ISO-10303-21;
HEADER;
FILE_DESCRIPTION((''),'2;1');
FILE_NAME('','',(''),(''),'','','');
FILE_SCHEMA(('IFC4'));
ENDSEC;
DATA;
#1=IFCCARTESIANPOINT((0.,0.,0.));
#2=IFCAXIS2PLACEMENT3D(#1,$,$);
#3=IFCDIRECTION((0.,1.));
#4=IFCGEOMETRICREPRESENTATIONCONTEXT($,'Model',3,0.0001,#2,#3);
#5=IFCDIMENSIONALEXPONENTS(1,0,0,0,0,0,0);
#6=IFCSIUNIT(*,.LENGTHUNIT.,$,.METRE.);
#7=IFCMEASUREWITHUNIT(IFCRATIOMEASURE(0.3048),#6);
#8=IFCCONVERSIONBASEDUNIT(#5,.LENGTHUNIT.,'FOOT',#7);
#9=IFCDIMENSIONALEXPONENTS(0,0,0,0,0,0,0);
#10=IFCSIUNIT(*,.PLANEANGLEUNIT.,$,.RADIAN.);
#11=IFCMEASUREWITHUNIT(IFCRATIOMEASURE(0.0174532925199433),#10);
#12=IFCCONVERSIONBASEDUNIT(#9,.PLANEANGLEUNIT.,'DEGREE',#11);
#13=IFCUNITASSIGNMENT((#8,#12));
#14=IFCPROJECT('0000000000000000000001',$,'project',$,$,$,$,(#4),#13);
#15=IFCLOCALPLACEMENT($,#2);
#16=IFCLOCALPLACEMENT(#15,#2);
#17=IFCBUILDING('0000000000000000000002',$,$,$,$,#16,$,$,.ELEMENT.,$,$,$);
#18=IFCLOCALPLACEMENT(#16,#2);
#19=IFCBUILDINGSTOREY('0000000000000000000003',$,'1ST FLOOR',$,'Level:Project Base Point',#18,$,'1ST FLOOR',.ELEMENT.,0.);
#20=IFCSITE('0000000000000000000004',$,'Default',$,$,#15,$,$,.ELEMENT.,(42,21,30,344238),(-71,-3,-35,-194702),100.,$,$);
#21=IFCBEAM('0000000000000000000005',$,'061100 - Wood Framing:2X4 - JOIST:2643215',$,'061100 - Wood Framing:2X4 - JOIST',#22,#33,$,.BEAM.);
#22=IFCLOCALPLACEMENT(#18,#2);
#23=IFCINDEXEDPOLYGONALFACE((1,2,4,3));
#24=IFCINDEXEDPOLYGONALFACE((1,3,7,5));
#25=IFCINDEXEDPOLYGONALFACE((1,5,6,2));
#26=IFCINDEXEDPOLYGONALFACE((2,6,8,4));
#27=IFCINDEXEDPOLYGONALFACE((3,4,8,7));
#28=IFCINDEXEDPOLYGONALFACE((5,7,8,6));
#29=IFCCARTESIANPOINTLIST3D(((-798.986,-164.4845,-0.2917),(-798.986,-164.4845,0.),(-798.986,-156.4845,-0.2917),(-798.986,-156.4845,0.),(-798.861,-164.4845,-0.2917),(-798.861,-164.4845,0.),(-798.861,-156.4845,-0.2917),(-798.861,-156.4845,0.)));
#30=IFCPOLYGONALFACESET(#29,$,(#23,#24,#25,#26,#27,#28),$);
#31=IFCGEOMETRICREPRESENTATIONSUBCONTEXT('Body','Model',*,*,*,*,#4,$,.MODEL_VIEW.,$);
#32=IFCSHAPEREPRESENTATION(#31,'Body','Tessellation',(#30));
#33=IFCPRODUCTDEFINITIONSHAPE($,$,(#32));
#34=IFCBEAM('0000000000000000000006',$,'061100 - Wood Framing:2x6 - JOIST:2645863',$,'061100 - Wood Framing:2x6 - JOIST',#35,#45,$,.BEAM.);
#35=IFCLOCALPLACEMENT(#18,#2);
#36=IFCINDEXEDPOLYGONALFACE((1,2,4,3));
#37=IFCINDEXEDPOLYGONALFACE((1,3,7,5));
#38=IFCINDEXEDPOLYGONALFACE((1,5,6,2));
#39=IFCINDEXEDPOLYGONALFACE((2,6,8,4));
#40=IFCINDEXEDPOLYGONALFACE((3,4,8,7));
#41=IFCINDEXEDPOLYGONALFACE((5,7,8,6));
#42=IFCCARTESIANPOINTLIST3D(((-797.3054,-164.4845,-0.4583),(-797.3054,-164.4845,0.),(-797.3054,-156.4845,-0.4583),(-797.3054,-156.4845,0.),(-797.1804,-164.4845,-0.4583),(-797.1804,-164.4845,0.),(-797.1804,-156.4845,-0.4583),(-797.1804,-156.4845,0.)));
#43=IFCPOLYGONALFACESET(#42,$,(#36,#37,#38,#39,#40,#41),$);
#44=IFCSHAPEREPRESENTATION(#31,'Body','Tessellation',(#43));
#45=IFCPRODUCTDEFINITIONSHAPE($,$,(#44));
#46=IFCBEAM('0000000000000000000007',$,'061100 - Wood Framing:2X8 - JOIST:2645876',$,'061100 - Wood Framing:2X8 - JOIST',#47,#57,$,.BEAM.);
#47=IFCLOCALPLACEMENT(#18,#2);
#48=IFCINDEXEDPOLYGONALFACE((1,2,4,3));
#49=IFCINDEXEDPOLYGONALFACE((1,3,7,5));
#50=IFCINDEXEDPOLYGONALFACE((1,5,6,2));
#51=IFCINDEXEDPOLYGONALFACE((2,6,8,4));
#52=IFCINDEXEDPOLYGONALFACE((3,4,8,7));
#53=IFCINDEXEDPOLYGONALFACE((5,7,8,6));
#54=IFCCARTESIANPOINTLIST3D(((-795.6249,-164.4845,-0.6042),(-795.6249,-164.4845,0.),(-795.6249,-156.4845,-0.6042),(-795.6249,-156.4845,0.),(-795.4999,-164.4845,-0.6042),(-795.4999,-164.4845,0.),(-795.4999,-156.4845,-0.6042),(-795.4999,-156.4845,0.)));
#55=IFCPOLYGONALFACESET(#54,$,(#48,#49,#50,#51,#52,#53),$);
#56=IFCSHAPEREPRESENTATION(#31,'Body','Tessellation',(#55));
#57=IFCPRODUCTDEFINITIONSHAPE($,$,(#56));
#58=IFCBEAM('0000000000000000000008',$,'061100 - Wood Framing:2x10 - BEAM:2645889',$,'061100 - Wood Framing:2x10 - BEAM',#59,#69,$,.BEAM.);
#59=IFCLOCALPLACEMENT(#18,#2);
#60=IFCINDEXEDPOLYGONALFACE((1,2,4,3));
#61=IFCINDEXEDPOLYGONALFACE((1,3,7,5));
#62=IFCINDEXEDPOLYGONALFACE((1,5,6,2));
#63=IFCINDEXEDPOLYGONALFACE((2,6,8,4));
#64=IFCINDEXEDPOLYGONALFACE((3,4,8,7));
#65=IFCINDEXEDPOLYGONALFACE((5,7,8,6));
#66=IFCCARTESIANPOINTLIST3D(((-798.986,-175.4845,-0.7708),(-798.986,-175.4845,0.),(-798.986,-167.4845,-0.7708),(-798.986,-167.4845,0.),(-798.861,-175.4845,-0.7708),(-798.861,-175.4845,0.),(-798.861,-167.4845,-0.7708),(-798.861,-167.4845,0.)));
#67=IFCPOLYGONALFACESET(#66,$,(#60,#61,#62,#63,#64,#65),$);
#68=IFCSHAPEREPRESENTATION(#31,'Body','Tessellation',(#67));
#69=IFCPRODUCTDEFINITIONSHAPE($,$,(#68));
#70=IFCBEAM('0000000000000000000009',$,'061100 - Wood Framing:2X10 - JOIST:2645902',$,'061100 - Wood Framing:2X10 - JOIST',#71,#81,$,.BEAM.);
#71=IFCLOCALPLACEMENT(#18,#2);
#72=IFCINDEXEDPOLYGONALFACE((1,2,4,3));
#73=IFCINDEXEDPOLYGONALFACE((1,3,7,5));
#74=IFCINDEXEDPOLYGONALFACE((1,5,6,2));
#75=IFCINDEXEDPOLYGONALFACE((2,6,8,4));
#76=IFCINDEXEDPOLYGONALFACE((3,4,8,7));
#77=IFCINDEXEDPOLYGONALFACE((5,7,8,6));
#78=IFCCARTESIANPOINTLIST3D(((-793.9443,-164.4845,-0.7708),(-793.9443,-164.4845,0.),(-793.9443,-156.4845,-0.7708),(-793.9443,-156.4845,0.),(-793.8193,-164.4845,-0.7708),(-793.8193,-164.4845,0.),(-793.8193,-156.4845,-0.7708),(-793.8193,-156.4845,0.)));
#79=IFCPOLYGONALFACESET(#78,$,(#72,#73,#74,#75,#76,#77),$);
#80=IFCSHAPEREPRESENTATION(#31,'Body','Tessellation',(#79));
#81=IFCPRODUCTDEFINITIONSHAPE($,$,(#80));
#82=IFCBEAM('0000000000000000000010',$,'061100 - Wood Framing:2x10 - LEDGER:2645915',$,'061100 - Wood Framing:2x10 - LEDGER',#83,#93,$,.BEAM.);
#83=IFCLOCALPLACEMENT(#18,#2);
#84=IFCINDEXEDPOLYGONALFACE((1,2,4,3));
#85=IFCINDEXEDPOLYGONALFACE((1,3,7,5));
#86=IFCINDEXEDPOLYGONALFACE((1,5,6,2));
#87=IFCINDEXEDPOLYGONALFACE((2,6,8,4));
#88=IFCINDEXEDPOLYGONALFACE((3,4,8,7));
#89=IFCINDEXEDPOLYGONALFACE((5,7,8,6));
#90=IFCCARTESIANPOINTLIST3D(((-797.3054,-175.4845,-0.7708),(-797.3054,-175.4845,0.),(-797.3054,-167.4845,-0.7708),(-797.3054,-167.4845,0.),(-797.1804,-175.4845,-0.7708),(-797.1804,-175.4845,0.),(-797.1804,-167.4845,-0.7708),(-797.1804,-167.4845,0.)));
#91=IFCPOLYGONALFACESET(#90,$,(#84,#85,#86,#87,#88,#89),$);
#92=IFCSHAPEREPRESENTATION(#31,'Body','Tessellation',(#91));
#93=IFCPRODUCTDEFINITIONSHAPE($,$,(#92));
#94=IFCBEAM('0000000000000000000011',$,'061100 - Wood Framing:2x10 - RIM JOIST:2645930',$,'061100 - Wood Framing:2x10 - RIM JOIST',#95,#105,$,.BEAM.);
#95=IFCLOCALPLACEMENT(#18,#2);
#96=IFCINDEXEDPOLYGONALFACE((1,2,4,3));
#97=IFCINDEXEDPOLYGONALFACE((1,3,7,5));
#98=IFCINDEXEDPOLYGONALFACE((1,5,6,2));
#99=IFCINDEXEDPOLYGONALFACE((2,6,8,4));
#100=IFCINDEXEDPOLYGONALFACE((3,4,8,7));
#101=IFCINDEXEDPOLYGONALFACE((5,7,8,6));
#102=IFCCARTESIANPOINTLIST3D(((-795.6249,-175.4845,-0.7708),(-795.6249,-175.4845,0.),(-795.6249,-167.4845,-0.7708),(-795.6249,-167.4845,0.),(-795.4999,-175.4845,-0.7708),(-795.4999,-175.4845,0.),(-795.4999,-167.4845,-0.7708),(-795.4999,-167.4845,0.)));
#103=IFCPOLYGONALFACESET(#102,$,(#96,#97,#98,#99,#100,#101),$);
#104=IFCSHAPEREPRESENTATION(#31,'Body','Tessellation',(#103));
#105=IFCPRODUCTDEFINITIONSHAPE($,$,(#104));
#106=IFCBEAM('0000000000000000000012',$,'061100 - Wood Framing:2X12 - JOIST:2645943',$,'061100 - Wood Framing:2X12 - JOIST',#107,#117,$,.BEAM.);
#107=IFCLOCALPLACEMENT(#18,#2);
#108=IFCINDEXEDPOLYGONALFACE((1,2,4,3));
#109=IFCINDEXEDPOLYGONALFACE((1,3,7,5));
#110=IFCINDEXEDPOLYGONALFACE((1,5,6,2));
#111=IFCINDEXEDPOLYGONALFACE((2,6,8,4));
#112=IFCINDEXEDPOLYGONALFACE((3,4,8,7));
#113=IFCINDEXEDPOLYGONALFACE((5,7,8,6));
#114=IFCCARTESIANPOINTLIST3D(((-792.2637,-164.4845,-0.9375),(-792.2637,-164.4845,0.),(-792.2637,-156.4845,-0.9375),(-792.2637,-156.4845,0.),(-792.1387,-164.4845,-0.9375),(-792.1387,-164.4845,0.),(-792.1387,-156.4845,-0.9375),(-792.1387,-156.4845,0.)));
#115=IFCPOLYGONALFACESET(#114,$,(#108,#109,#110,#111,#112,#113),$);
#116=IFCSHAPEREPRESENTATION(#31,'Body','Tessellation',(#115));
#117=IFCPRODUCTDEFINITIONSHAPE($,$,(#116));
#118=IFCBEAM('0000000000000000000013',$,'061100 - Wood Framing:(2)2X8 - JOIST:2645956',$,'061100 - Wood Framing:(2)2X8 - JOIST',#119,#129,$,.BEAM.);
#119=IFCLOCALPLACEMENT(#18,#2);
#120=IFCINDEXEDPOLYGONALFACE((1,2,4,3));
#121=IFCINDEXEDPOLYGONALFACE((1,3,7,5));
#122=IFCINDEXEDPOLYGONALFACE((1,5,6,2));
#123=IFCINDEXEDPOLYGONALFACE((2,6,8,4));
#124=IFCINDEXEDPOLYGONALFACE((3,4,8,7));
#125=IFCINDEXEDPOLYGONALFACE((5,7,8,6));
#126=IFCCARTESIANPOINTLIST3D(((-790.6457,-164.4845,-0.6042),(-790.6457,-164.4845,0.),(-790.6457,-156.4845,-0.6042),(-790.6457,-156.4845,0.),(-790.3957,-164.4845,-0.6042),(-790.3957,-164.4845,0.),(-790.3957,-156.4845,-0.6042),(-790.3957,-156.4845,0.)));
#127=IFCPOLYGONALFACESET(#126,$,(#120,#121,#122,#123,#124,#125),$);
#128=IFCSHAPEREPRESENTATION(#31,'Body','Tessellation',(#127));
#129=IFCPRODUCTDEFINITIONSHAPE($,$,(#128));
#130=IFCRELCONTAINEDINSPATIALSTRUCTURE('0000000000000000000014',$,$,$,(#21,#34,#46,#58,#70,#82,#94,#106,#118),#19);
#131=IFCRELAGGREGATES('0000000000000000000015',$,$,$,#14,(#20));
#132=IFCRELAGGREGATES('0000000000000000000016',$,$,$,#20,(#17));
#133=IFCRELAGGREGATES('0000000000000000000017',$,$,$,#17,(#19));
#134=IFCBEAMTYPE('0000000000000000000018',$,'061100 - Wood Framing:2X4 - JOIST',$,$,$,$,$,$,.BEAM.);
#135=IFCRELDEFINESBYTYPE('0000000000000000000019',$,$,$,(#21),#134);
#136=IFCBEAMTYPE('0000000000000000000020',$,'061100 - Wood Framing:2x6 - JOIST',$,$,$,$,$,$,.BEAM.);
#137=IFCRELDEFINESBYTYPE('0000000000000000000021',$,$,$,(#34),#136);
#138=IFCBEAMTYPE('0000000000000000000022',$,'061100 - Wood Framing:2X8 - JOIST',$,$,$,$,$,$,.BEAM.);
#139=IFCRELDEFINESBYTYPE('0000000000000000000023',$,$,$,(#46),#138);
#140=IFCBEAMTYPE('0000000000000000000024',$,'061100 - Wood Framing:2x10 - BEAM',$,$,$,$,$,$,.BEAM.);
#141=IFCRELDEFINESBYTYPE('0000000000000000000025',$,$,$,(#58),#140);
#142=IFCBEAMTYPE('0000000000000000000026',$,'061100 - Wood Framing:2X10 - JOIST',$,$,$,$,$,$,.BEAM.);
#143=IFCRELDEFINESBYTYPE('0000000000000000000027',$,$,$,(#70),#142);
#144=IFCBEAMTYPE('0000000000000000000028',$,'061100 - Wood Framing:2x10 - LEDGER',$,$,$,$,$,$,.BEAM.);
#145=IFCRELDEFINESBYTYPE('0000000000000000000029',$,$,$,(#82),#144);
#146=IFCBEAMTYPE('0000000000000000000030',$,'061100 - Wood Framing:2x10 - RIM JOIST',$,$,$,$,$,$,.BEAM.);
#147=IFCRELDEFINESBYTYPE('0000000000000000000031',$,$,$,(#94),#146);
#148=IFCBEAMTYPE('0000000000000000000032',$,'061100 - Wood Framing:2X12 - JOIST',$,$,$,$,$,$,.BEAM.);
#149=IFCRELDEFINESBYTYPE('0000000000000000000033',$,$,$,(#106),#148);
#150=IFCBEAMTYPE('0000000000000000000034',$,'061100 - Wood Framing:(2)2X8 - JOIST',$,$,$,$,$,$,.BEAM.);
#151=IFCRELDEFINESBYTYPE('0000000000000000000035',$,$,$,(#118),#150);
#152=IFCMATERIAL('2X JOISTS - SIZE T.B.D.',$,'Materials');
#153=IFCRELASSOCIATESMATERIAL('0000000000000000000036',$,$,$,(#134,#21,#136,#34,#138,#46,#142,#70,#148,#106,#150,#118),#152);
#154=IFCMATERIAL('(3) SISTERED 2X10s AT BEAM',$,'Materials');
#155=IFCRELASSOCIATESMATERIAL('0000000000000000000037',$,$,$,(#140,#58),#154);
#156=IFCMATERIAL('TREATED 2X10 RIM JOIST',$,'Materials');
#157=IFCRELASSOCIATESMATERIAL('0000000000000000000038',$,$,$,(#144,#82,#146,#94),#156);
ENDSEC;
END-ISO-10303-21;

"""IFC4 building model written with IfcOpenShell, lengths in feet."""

from ifc_helpers import new_model, entity, si_unit, converted_unit, direction, frame, frame_2d, origin, origin_2d_with_axis, place, context, subcontext, project, spatial, rectangle, extrude, source, transform, mapped, material, material_profile, profile_set, profile_usage, type_object, type_shapes, element, save


model = new_model("IFC4")

# Units and contexts
model_context = context("Model", 3, precision=0.0001, world=origin(), true_north=direction((0.0, 1.0)))
body_context = subcontext(model_context, "Body", "Model", "MODEL_VIEW")
ifc_project = project(units=[converted_unit("LENGTHUNIT", "FOOT", entity("IfcRatioMeasure", 0.3048), si_unit("LENGTHUNIT", "METRE"), dimensions=[1, 0, 0, 0, 0, 0, 0]), converted_unit("PLANEANGLEUNIT", "DEGREE", entity("IfcRatioMeasure", 0.0174532925199433), si_unit("PLANEANGLEUNIT", "RADIAN"), dimensions=[0, 0, 0, 0, 0, 0, 0])], contexts=[model_context])

# Site, building, storey
site_placement = place(None, origin())
site = spatial("IfcSite", under=ifc_project, at=site_placement, Name="Default", CompositionType="ELEMENT", RefLatitude=(42, 21, 30, 344238), RefLongitude=(-71, -3, -35, -194702), RefElevation=100.0)
building_placement = place(site_placement, origin())
building = spatial("IfcBuilding", under=site, at=building_placement, CompositionType="ELEMENT")
storey_placement = place(building_placement, origin())
storey = spatial("IfcBuildingStorey", under=building, at=storey_placement, Name="1ST FLOOR", ObjectType="Level:Project Base Point", LongName="1ST FLOOR", CompositionType="ELEMENT", Elevation=0.0)

# Beams
ifc_material_1 = material(Name="2X JOISTS - SIZE T.B.D.", Category="Materials")
ifc_material_profile_1 = material_profile(ifc_material_1, rectangle(XDim=0.2917, YDim=0.125, at=origin_2d_with_axis()), Name="2X4 - JOIST")
ifc_profile_set_1 = profile_set([ifc_material_profile_1], Name="2X4 - JOIST")
ifc_profile_usage_1 = profile_usage(ifc_profile_set_1, cardinal=8)
beam_type_1 = type_object("IfcBeamType", Name="061100 - Wood Framing:2X4 - JOIST", PredefinedType="BEAM", material=ifc_profile_set_1)
shared_shape_1 = source(origin(), body_context, "Body", "SweptSolid", [
    extrude(rectangle(XDim=0.2917, YDim=0.125, at=origin_2d_with_axis()), frame((-4.0, 0.0, 0.0), z_axis=(1.0, 0.0, 0.0), x_axis=(0.0, 0.0, -1.0)), (0.0, 0.0, 1.0), 8.0),
])
type_shapes(beam_type_1, [shared_shape_1])
beam_1_placement = place(storey_placement, frame((-798.9235, -160.4845, -0.1458), z_axis=(0.0, 0.0, 1.0), x_axis=(0.0, -1.0, 0.0)))
element("IfcBeam", 1, at=beam_1_placement, inside=storey, type_object=beam_type_1, material=ifc_profile_usage_1, Name="061100 - Wood Framing:2X4 - JOIST:2643215", ObjectType="061100 - Wood Framing:2X4 - JOIST", PredefinedType="BEAM", context=body_context, shape_type="MappedRepresentation", body=[
    mapped(shared_shape_1, transform((0.0, 0.0, 0.0), scale=1.0)),
])
ifc_material_profile_2 = material_profile(ifc_material_1, rectangle(XDim=0.4583, YDim=0.125, at=origin_2d_with_axis()), Name="2x6 - JOIST")
ifc_profile_set_2 = profile_set([ifc_material_profile_2], Name="2x6 - JOIST")
ifc_profile_usage_2 = profile_usage(ifc_profile_set_2, cardinal=8)
beam_type_2 = type_object("IfcBeamType", Name="061100 - Wood Framing:2x6 - JOIST", PredefinedType="BEAM", material=ifc_profile_set_2)
shared_shape_2 = source(origin(), body_context, "Body", "SweptSolid", [
    extrude(rectangle(XDim=0.4583, YDim=0.125, at=origin_2d_with_axis()), frame((-4.0, 0.0, 0.0), z_axis=(1.0, 0.0, 0.0), x_axis=(0.0, 0.0, -1.0)), (0.0, 0.0, 1.0), 8.0),
])
type_shapes(beam_type_2, [shared_shape_2])
beam_2_placement = place(storey_placement, frame((-797.2429, -160.4845, -0.2292), z_axis=(0.0, 0.0, 1.0), x_axis=(0.0, -1.0, 0.0)))
element("IfcBeam", 2, at=beam_2_placement, inside=storey, type_object=beam_type_2, material=ifc_profile_usage_2, Name="061100 - Wood Framing:2x6 - JOIST:2645863", ObjectType="061100 - Wood Framing:2x6 - JOIST", PredefinedType="BEAM", context=body_context, shape_type="MappedRepresentation", body=[
    mapped(shared_shape_2, transform((0.0, 0.0, 0.0), scale=1.0)),
])
ifc_material_profile_3 = material_profile(ifc_material_1, rectangle(XDim=0.6042, YDim=0.125, at=origin_2d_with_axis()), Name="2X8 - JOIST")
ifc_profile_set_3 = profile_set([ifc_material_profile_3], Name="2X8 - JOIST")
ifc_profile_usage_3 = profile_usage(ifc_profile_set_3, cardinal=8)
beam_type_3 = type_object("IfcBeamType", Name="061100 - Wood Framing:2X8 - JOIST", PredefinedType="BEAM", material=ifc_profile_set_3)
shared_shape_3 = source(origin(), body_context, "Body", "SweptSolid", [
    extrude(rectangle(XDim=0.6042, YDim=0.125, at=origin_2d_with_axis()), frame((-4.0, 0.0, 0.0), z_axis=(1.0, 0.0, 0.0), x_axis=(0.0, 0.0, -1.0)), (0.0, 0.0, 1.0), 8.0),
])
type_shapes(beam_type_3, [shared_shape_3])
beam_3_placement = place(storey_placement, frame((-795.5624, -160.4845, -0.3021), z_axis=(0.0, 0.0, 1.0), x_axis=(0.0, -1.0, 0.0)))
element("IfcBeam", 3, at=beam_3_placement, inside=storey, type_object=beam_type_3, material=ifc_profile_usage_3, Name="061100 - Wood Framing:2X8 - JOIST:2645876", ObjectType="061100 - Wood Framing:2X8 - JOIST", PredefinedType="BEAM", context=body_context, shape_type="MappedRepresentation", body=[
    mapped(shared_shape_3, transform((0.0, 0.0, 0.0), scale=1.0)),
])
ifc_material_2 = material(Name="(3) SISTERED 2X10s AT BEAM", Category="Materials")
ifc_material_profile_4 = material_profile(ifc_material_2, rectangle(XDim=0.7708, YDim=0.125, at=frame_2d((0.0, 0.0), x_axis=(1.0, 0.0))), Name="2x10 - BEAM")
ifc_profile_set_4 = profile_set([ifc_material_profile_4], Name="2x10 - BEAM")
ifc_profile_usage_4 = profile_usage(ifc_profile_set_4, cardinal=8)
beam_type_4 = type_object("IfcBeamType", Name="061100 - Wood Framing:2x10 - BEAM", PredefinedType="BEAM", material=ifc_profile_set_4)
shared_shape_4 = source(origin(), body_context, "Body", "SweptSolid", [
    extrude(rectangle(XDim=0.7708, YDim=0.125, at=frame_2d((0.0, 0.0), x_axis=(1.0, 0.0))), frame((-4.0, 0.0, 0.0), z_axis=(1.0, 0.0, 0.0), x_axis=(0.0, 0.0, -1.0)), (0.0, 0.0, 1.0), 8.0),
])
type_shapes(beam_type_4, [shared_shape_4])
beam_4_placement = place(storey_placement, frame((-798.9235, -171.4845, -0.3854), z_axis=(0.0, 0.0, 1.0), x_axis=(0.0, -1.0, 0.0)))
element("IfcBeam", 4, at=beam_4_placement, inside=storey, type_object=beam_type_4, material=ifc_profile_usage_4, Name="061100 - Wood Framing:2x10 - BEAM:2645889", ObjectType="061100 - Wood Framing:2x10 - BEAM", PredefinedType="BEAM", context=body_context, shape_type="MappedRepresentation", body=[
    mapped(shared_shape_4, transform((0.0, 0.0, 0.0), scale=1.0)),
])
ifc_material_profile_5 = material_profile(ifc_material_1, rectangle(XDim=0.7708, YDim=0.125, at=frame_2d((0.0, 0.0), x_axis=(1.0, 0.0))), Name="2X10 - JOIST")
ifc_profile_set_5 = profile_set([ifc_material_profile_5], Name="2X10 - JOIST")
ifc_profile_usage_5 = profile_usage(ifc_profile_set_5, cardinal=8)
beam_type_5 = type_object("IfcBeamType", Name="061100 - Wood Framing:2X10 - JOIST", PredefinedType="BEAM", material=ifc_profile_set_5)
shared_shape_5 = source(origin(), body_context, "Body", "SweptSolid", [
    extrude(rectangle(XDim=0.7708, YDim=0.125, at=frame_2d((0.0, 0.0), x_axis=(1.0, 0.0))), frame((-4.0, 0.0, 0.0), z_axis=(1.0, 0.0, 0.0), x_axis=(0.0, 0.0, -1.0)), (0.0, 0.0, 1.0), 8.0),
])
type_shapes(beam_type_5, [shared_shape_5])
beam_5_placement = place(storey_placement, frame((-793.8818, -160.4845, -0.3854), z_axis=(0.0, 0.0, 1.0), x_axis=(0.0, -1.0, 0.0)))
element("IfcBeam", 5, at=beam_5_placement, inside=storey, type_object=beam_type_5, material=ifc_profile_usage_5, Name="061100 - Wood Framing:2X10 - JOIST:2645902", ObjectType="061100 - Wood Framing:2X10 - JOIST", PredefinedType="BEAM", context=body_context, shape_type="MappedRepresentation", body=[
    mapped(shared_shape_5, transform((0.0, 0.0, 0.0), scale=1.0)),
])
ifc_material_3 = material(Name="TREATED 2X10 RIM JOIST", Category="Materials")
ifc_material_profile_6 = material_profile(ifc_material_3, rectangle(XDim=0.7708, YDim=0.125, at=frame_2d((0.0, 0.0), x_axis=(1.0, 0.0))), Name="2x10 - LEDGER")
ifc_profile_set_6 = profile_set([ifc_material_profile_6], Name="2x10 - LEDGER")
ifc_profile_usage_6 = profile_usage(ifc_profile_set_6, cardinal=8)
beam_type_6 = type_object("IfcBeamType", Name="061100 - Wood Framing:2x10 - LEDGER", PredefinedType="BEAM", material=ifc_profile_set_6)
shared_shape_6 = source(origin(), body_context, "Body", "SweptSolid", [
    extrude(rectangle(XDim=0.7708, YDim=0.125, at=frame_2d((0.0, 0.0), x_axis=(1.0, 0.0))), frame((-4.0, 0.0, 0.0), z_axis=(1.0, 0.0, 0.0), x_axis=(0.0, 0.0, -1.0)), (0.0, 0.0, 1.0), 8.0),
])
type_shapes(beam_type_6, [shared_shape_6])
beam_6_placement = place(storey_placement, frame((-797.2429, -171.4845, -0.3854), z_axis=(0.0, 0.0, 1.0), x_axis=(0.0, -1.0, 0.0)))
element("IfcBeam", 6, at=beam_6_placement, inside=storey, type_object=beam_type_6, material=ifc_profile_usage_6, Name="061100 - Wood Framing:2x10 - LEDGER:2645915", ObjectType="061100 - Wood Framing:2x10 - LEDGER", PredefinedType="BEAM", context=body_context, shape_type="MappedRepresentation", body=[
    mapped(shared_shape_6, transform((0.0, 0.0, 0.0), scale=1.0)),
])
ifc_material_profile_7 = material_profile(ifc_material_3, rectangle(XDim=0.7708, YDim=0.125, at=origin_2d_with_axis()), Name="2x10 - RIM JOIST")
ifc_profile_set_7 = profile_set([ifc_material_profile_7], Name="2x10 - RIM JOIST")
ifc_profile_usage_7 = profile_usage(ifc_profile_set_7, cardinal=8)
beam_type_7 = type_object("IfcBeamType", Name="061100 - Wood Framing:2x10 - RIM JOIST", PredefinedType="BEAM", material=ifc_profile_set_7)
shared_shape_7 = source(origin(), body_context, "Body", "SweptSolid", [
    extrude(rectangle(XDim=0.7708, YDim=0.125, at=frame_2d((0.0, 0.0), x_axis=(1.0, 0.0))), frame((-4.0, 0.0, 0.0), z_axis=(1.0, 0.0, 0.0), x_axis=(0.0, 0.0, -1.0)), (0.0, 0.0, 1.0), 8.0),
])
type_shapes(beam_type_7, [shared_shape_7])
beam_7_placement = place(storey_placement, frame((-795.5624, -171.4845, -0.3854), z_axis=(0.0, 0.0, 1.0), x_axis=(0.0, -1.0, 0.0)))
element("IfcBeam", 7, at=beam_7_placement, inside=storey, type_object=beam_type_7, material=ifc_profile_usage_7, Name="061100 - Wood Framing:2x10 - RIM JOIST:2645930", ObjectType="061100 - Wood Framing:2x10 - RIM JOIST", PredefinedType="BEAM", context=body_context, shape_type="MappedRepresentation", body=[
    mapped(shared_shape_7, transform((0.0, 0.0, 0.0), scale=1.0)),
])
ifc_material_profile_8 = material_profile(ifc_material_1, rectangle(XDim=0.9375, YDim=0.125, at=origin_2d_with_axis()), Name="2X12 - JOIST")
ifc_profile_set_8 = profile_set([ifc_material_profile_8], Name="2X12 - JOIST")
ifc_profile_usage_8 = profile_usage(ifc_profile_set_8, cardinal=8)
beam_type_8 = type_object("IfcBeamType", Name="061100 - Wood Framing:2X12 - JOIST", PredefinedType="BEAM", material=ifc_profile_set_8)
shared_shape_8 = source(origin(), body_context, "Body", "SweptSolid", [
    extrude(rectangle(XDim=0.9375, YDim=0.125, at=origin_2d_with_axis()), frame((-4.0, 0.0, 0.0), z_axis=(1.0, 0.0, 0.0), x_axis=(0.0, 0.0, -1.0)), (0.0, 0.0, 1.0), 8.0),
])
type_shapes(beam_type_8, [shared_shape_8])
beam_8_placement = place(storey_placement, frame((-792.2012, -160.4845, -0.4687), z_axis=(0.0, 0.0, 1.0), x_axis=(0.0, -1.0, 0.0)))
element("IfcBeam", 8, at=beam_8_placement, inside=storey, type_object=beam_type_8, material=ifc_profile_usage_8, Name="061100 - Wood Framing:2X12 - JOIST:2645943", ObjectType="061100 - Wood Framing:2X12 - JOIST", PredefinedType="BEAM", context=body_context, shape_type="MappedRepresentation", body=[
    mapped(shared_shape_8, transform((0.0, 0.0, 0.0), scale=1.0)),
])
ifc_material_profile_9 = material_profile(ifc_material_1, rectangle(XDim=0.6042, YDim=0.25, at=origin_2d_with_axis()), Name="(2)2X8 - JOIST")
ifc_profile_set_9 = profile_set([ifc_material_profile_9], Name="(2)2X8 - JOIST")
ifc_profile_usage_9 = profile_usage(ifc_profile_set_9, cardinal=8)
beam_type_9 = type_object("IfcBeamType", Name="061100 - Wood Framing:(2)2X8 - JOIST", PredefinedType="BEAM", material=ifc_profile_set_9)
shared_shape_9 = source(origin(), body_context, "Body", "SweptSolid", [
    extrude(rectangle(XDim=0.6042, YDim=0.25, at=origin_2d_with_axis()), frame((-4.0, 0.0, 0.0), z_axis=(1.0, 0.0, 0.0), x_axis=(0.0, 0.0, -1.0)), (0.0, 0.0, 1.0), 8.0),
])
type_shapes(beam_type_9, [shared_shape_9])
beam_9_placement = place(storey_placement, frame((-790.5207, -160.4845, -0.3021), z_axis=(0.0, 0.0, 1.0), x_axis=(0.0, -1.0, 0.0)))
element("IfcBeam", 9, at=beam_9_placement, inside=storey, type_object=beam_type_9, material=ifc_profile_usage_9, Name="061100 - Wood Framing:(2)2X8 - JOIST:2645956", ObjectType="061100 - Wood Framing:(2)2X8 - JOIST", PredefinedType="BEAM", context=body_context, shape_type="MappedRepresentation", body=[
    mapped(shared_shape_9, transform((0.0, 0.0, 0.0), scale=1.0)),
])

save(model, "model.ifc")
